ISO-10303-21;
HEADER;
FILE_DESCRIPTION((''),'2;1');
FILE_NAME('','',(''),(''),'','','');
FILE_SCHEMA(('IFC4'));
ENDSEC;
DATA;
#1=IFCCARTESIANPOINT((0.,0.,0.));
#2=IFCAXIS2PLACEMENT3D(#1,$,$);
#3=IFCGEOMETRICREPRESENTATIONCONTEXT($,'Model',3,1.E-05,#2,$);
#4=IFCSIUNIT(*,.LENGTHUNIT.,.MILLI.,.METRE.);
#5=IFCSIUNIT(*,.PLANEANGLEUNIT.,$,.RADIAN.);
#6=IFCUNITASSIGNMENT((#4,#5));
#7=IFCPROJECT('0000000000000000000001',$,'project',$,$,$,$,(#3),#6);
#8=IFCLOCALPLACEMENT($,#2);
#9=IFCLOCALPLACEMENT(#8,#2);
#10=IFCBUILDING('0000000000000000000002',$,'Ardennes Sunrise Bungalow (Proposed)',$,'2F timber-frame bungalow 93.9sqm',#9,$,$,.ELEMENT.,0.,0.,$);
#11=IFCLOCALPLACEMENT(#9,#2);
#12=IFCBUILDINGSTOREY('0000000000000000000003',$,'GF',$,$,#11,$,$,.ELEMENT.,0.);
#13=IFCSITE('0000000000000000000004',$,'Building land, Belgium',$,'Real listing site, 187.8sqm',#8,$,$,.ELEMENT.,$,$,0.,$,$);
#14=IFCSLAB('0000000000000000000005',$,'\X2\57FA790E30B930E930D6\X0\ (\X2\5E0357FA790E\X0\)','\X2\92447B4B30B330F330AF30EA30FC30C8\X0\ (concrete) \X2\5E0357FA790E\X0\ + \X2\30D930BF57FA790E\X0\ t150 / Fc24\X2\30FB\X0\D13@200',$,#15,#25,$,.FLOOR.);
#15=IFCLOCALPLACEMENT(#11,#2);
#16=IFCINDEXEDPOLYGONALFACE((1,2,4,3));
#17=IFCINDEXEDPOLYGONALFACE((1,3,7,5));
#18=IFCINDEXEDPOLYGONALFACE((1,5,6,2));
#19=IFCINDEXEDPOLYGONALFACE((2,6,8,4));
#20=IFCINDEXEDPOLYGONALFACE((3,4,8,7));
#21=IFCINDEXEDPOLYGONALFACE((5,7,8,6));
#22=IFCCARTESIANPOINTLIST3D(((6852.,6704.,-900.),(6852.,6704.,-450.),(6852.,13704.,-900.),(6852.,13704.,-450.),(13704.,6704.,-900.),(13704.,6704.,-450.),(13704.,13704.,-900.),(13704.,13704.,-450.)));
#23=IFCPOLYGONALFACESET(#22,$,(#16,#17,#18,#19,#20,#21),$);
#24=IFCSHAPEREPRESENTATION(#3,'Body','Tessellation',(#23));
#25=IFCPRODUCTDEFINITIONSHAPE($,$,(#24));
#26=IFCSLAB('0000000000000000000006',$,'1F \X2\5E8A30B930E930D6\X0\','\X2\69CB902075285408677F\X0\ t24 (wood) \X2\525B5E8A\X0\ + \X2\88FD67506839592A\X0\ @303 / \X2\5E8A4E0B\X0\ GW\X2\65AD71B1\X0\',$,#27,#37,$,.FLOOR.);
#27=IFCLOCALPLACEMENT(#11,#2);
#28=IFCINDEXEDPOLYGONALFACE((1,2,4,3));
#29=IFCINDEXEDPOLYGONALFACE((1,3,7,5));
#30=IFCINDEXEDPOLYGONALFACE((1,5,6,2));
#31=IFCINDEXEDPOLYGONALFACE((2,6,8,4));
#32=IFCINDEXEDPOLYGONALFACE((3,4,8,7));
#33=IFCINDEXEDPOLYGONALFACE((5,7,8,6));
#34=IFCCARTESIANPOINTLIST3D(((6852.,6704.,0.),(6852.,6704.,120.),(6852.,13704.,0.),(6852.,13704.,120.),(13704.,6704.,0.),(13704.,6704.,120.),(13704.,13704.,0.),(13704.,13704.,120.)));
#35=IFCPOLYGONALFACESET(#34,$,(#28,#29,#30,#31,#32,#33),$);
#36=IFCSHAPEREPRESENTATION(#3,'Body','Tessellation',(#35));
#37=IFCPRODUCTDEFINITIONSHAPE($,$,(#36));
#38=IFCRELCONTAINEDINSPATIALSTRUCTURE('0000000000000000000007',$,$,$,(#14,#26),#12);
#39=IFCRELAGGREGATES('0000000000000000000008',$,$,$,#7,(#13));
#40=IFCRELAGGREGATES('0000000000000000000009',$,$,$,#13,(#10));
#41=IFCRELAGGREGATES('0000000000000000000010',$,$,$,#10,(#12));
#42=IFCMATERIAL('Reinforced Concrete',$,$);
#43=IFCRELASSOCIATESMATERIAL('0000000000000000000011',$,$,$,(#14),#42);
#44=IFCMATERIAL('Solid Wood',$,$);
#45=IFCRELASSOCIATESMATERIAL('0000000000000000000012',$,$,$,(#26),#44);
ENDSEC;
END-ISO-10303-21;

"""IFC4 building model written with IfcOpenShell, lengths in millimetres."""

from ifc_helpers import new_model, si_unit, frame, frame_2d, origin, place, context, project, spatial, rectangle, extrude, material, element, save


model = new_model("IFC4")

# Units and contexts
model_context = context("Model", 3, precision=1e-05, world=origin())
ifc_project = project(units=[si_unit("LENGTHUNIT", "METRE", prefix="MILLI"), si_unit("PLANEANGLEUNIT", "RADIAN")], contexts=[model_context])

# Site, building, storey
site_placement = place(None, origin())
site = spatial("IfcSite", under=ifc_project, at=site_placement, Name="Building land, Belgium", ObjectType="Real listing site, 187.8sqm", CompositionType="ELEMENT", RefElevation=0.0)
building_placement = place(site_placement, origin())
building = spatial("IfcBuilding", under=site, at=building_placement, Name="Ardennes Sunrise Bungalow (Proposed)", ObjectType="2F timber-frame bungalow 93.9sqm", CompositionType="ELEMENT", ElevationOfRefHeight=0.0, ElevationOfTerrain=0.0)
storey_placement = place(building_placement, origin())
storey = spatial("IfcBuildingStorey", under=building, at=storey_placement, Name="GF", CompositionType="ELEMENT", Elevation=0.0)

# Slabs
ifc_material_1 = material(Name="Reinforced Concrete")
slab_1_placement = place(storey_placement, frame((3426.0, 3352.0, -450.0)))
element("IfcSlab", 1, at=slab_1_placement, inside=storey, material=ifc_material_1, Name="基礎スラブ (布基礎)", Description="鉄筋コンクリート (concrete) 布基礎 + ベタ基礎 t150 / Fc24・D13@200", PredefinedType="FLOOR", context=model_context, shape_type="SweptSolid", body=[
    extrude(rectangle(XDim=6852.0, YDim=7000.0, at=frame_2d((3426.0, 3500.0))), frame((3426.0, 3352.0, -450.0)), (0.0, 0.0, 1.0), 450.0),
])
ifc_material_2 = material(Name="Solid Wood")
slab_2_placement = place(storey_placement, frame((3426.0, 3352.0, 0.0)))
element("IfcSlab", 2, at=slab_2_placement, inside=storey, material=ifc_material_2, Name="1F 床スラブ", Description="構造用合板 t24 (wood) 剛床 + 製材根太 @303 / 床下 GW断熱", PredefinedType="FLOOR", context=model_context, shape_type="SweptSolid", body=[
    extrude(rectangle(XDim=6852.0, YDim=7000.0, at=frame_2d((3426.0, 3500.0))), frame((3426.0, 3352.0, 0.0)), (0.0, 0.0, 1.0), 120.0),
])

save(model, "model.ifc")
